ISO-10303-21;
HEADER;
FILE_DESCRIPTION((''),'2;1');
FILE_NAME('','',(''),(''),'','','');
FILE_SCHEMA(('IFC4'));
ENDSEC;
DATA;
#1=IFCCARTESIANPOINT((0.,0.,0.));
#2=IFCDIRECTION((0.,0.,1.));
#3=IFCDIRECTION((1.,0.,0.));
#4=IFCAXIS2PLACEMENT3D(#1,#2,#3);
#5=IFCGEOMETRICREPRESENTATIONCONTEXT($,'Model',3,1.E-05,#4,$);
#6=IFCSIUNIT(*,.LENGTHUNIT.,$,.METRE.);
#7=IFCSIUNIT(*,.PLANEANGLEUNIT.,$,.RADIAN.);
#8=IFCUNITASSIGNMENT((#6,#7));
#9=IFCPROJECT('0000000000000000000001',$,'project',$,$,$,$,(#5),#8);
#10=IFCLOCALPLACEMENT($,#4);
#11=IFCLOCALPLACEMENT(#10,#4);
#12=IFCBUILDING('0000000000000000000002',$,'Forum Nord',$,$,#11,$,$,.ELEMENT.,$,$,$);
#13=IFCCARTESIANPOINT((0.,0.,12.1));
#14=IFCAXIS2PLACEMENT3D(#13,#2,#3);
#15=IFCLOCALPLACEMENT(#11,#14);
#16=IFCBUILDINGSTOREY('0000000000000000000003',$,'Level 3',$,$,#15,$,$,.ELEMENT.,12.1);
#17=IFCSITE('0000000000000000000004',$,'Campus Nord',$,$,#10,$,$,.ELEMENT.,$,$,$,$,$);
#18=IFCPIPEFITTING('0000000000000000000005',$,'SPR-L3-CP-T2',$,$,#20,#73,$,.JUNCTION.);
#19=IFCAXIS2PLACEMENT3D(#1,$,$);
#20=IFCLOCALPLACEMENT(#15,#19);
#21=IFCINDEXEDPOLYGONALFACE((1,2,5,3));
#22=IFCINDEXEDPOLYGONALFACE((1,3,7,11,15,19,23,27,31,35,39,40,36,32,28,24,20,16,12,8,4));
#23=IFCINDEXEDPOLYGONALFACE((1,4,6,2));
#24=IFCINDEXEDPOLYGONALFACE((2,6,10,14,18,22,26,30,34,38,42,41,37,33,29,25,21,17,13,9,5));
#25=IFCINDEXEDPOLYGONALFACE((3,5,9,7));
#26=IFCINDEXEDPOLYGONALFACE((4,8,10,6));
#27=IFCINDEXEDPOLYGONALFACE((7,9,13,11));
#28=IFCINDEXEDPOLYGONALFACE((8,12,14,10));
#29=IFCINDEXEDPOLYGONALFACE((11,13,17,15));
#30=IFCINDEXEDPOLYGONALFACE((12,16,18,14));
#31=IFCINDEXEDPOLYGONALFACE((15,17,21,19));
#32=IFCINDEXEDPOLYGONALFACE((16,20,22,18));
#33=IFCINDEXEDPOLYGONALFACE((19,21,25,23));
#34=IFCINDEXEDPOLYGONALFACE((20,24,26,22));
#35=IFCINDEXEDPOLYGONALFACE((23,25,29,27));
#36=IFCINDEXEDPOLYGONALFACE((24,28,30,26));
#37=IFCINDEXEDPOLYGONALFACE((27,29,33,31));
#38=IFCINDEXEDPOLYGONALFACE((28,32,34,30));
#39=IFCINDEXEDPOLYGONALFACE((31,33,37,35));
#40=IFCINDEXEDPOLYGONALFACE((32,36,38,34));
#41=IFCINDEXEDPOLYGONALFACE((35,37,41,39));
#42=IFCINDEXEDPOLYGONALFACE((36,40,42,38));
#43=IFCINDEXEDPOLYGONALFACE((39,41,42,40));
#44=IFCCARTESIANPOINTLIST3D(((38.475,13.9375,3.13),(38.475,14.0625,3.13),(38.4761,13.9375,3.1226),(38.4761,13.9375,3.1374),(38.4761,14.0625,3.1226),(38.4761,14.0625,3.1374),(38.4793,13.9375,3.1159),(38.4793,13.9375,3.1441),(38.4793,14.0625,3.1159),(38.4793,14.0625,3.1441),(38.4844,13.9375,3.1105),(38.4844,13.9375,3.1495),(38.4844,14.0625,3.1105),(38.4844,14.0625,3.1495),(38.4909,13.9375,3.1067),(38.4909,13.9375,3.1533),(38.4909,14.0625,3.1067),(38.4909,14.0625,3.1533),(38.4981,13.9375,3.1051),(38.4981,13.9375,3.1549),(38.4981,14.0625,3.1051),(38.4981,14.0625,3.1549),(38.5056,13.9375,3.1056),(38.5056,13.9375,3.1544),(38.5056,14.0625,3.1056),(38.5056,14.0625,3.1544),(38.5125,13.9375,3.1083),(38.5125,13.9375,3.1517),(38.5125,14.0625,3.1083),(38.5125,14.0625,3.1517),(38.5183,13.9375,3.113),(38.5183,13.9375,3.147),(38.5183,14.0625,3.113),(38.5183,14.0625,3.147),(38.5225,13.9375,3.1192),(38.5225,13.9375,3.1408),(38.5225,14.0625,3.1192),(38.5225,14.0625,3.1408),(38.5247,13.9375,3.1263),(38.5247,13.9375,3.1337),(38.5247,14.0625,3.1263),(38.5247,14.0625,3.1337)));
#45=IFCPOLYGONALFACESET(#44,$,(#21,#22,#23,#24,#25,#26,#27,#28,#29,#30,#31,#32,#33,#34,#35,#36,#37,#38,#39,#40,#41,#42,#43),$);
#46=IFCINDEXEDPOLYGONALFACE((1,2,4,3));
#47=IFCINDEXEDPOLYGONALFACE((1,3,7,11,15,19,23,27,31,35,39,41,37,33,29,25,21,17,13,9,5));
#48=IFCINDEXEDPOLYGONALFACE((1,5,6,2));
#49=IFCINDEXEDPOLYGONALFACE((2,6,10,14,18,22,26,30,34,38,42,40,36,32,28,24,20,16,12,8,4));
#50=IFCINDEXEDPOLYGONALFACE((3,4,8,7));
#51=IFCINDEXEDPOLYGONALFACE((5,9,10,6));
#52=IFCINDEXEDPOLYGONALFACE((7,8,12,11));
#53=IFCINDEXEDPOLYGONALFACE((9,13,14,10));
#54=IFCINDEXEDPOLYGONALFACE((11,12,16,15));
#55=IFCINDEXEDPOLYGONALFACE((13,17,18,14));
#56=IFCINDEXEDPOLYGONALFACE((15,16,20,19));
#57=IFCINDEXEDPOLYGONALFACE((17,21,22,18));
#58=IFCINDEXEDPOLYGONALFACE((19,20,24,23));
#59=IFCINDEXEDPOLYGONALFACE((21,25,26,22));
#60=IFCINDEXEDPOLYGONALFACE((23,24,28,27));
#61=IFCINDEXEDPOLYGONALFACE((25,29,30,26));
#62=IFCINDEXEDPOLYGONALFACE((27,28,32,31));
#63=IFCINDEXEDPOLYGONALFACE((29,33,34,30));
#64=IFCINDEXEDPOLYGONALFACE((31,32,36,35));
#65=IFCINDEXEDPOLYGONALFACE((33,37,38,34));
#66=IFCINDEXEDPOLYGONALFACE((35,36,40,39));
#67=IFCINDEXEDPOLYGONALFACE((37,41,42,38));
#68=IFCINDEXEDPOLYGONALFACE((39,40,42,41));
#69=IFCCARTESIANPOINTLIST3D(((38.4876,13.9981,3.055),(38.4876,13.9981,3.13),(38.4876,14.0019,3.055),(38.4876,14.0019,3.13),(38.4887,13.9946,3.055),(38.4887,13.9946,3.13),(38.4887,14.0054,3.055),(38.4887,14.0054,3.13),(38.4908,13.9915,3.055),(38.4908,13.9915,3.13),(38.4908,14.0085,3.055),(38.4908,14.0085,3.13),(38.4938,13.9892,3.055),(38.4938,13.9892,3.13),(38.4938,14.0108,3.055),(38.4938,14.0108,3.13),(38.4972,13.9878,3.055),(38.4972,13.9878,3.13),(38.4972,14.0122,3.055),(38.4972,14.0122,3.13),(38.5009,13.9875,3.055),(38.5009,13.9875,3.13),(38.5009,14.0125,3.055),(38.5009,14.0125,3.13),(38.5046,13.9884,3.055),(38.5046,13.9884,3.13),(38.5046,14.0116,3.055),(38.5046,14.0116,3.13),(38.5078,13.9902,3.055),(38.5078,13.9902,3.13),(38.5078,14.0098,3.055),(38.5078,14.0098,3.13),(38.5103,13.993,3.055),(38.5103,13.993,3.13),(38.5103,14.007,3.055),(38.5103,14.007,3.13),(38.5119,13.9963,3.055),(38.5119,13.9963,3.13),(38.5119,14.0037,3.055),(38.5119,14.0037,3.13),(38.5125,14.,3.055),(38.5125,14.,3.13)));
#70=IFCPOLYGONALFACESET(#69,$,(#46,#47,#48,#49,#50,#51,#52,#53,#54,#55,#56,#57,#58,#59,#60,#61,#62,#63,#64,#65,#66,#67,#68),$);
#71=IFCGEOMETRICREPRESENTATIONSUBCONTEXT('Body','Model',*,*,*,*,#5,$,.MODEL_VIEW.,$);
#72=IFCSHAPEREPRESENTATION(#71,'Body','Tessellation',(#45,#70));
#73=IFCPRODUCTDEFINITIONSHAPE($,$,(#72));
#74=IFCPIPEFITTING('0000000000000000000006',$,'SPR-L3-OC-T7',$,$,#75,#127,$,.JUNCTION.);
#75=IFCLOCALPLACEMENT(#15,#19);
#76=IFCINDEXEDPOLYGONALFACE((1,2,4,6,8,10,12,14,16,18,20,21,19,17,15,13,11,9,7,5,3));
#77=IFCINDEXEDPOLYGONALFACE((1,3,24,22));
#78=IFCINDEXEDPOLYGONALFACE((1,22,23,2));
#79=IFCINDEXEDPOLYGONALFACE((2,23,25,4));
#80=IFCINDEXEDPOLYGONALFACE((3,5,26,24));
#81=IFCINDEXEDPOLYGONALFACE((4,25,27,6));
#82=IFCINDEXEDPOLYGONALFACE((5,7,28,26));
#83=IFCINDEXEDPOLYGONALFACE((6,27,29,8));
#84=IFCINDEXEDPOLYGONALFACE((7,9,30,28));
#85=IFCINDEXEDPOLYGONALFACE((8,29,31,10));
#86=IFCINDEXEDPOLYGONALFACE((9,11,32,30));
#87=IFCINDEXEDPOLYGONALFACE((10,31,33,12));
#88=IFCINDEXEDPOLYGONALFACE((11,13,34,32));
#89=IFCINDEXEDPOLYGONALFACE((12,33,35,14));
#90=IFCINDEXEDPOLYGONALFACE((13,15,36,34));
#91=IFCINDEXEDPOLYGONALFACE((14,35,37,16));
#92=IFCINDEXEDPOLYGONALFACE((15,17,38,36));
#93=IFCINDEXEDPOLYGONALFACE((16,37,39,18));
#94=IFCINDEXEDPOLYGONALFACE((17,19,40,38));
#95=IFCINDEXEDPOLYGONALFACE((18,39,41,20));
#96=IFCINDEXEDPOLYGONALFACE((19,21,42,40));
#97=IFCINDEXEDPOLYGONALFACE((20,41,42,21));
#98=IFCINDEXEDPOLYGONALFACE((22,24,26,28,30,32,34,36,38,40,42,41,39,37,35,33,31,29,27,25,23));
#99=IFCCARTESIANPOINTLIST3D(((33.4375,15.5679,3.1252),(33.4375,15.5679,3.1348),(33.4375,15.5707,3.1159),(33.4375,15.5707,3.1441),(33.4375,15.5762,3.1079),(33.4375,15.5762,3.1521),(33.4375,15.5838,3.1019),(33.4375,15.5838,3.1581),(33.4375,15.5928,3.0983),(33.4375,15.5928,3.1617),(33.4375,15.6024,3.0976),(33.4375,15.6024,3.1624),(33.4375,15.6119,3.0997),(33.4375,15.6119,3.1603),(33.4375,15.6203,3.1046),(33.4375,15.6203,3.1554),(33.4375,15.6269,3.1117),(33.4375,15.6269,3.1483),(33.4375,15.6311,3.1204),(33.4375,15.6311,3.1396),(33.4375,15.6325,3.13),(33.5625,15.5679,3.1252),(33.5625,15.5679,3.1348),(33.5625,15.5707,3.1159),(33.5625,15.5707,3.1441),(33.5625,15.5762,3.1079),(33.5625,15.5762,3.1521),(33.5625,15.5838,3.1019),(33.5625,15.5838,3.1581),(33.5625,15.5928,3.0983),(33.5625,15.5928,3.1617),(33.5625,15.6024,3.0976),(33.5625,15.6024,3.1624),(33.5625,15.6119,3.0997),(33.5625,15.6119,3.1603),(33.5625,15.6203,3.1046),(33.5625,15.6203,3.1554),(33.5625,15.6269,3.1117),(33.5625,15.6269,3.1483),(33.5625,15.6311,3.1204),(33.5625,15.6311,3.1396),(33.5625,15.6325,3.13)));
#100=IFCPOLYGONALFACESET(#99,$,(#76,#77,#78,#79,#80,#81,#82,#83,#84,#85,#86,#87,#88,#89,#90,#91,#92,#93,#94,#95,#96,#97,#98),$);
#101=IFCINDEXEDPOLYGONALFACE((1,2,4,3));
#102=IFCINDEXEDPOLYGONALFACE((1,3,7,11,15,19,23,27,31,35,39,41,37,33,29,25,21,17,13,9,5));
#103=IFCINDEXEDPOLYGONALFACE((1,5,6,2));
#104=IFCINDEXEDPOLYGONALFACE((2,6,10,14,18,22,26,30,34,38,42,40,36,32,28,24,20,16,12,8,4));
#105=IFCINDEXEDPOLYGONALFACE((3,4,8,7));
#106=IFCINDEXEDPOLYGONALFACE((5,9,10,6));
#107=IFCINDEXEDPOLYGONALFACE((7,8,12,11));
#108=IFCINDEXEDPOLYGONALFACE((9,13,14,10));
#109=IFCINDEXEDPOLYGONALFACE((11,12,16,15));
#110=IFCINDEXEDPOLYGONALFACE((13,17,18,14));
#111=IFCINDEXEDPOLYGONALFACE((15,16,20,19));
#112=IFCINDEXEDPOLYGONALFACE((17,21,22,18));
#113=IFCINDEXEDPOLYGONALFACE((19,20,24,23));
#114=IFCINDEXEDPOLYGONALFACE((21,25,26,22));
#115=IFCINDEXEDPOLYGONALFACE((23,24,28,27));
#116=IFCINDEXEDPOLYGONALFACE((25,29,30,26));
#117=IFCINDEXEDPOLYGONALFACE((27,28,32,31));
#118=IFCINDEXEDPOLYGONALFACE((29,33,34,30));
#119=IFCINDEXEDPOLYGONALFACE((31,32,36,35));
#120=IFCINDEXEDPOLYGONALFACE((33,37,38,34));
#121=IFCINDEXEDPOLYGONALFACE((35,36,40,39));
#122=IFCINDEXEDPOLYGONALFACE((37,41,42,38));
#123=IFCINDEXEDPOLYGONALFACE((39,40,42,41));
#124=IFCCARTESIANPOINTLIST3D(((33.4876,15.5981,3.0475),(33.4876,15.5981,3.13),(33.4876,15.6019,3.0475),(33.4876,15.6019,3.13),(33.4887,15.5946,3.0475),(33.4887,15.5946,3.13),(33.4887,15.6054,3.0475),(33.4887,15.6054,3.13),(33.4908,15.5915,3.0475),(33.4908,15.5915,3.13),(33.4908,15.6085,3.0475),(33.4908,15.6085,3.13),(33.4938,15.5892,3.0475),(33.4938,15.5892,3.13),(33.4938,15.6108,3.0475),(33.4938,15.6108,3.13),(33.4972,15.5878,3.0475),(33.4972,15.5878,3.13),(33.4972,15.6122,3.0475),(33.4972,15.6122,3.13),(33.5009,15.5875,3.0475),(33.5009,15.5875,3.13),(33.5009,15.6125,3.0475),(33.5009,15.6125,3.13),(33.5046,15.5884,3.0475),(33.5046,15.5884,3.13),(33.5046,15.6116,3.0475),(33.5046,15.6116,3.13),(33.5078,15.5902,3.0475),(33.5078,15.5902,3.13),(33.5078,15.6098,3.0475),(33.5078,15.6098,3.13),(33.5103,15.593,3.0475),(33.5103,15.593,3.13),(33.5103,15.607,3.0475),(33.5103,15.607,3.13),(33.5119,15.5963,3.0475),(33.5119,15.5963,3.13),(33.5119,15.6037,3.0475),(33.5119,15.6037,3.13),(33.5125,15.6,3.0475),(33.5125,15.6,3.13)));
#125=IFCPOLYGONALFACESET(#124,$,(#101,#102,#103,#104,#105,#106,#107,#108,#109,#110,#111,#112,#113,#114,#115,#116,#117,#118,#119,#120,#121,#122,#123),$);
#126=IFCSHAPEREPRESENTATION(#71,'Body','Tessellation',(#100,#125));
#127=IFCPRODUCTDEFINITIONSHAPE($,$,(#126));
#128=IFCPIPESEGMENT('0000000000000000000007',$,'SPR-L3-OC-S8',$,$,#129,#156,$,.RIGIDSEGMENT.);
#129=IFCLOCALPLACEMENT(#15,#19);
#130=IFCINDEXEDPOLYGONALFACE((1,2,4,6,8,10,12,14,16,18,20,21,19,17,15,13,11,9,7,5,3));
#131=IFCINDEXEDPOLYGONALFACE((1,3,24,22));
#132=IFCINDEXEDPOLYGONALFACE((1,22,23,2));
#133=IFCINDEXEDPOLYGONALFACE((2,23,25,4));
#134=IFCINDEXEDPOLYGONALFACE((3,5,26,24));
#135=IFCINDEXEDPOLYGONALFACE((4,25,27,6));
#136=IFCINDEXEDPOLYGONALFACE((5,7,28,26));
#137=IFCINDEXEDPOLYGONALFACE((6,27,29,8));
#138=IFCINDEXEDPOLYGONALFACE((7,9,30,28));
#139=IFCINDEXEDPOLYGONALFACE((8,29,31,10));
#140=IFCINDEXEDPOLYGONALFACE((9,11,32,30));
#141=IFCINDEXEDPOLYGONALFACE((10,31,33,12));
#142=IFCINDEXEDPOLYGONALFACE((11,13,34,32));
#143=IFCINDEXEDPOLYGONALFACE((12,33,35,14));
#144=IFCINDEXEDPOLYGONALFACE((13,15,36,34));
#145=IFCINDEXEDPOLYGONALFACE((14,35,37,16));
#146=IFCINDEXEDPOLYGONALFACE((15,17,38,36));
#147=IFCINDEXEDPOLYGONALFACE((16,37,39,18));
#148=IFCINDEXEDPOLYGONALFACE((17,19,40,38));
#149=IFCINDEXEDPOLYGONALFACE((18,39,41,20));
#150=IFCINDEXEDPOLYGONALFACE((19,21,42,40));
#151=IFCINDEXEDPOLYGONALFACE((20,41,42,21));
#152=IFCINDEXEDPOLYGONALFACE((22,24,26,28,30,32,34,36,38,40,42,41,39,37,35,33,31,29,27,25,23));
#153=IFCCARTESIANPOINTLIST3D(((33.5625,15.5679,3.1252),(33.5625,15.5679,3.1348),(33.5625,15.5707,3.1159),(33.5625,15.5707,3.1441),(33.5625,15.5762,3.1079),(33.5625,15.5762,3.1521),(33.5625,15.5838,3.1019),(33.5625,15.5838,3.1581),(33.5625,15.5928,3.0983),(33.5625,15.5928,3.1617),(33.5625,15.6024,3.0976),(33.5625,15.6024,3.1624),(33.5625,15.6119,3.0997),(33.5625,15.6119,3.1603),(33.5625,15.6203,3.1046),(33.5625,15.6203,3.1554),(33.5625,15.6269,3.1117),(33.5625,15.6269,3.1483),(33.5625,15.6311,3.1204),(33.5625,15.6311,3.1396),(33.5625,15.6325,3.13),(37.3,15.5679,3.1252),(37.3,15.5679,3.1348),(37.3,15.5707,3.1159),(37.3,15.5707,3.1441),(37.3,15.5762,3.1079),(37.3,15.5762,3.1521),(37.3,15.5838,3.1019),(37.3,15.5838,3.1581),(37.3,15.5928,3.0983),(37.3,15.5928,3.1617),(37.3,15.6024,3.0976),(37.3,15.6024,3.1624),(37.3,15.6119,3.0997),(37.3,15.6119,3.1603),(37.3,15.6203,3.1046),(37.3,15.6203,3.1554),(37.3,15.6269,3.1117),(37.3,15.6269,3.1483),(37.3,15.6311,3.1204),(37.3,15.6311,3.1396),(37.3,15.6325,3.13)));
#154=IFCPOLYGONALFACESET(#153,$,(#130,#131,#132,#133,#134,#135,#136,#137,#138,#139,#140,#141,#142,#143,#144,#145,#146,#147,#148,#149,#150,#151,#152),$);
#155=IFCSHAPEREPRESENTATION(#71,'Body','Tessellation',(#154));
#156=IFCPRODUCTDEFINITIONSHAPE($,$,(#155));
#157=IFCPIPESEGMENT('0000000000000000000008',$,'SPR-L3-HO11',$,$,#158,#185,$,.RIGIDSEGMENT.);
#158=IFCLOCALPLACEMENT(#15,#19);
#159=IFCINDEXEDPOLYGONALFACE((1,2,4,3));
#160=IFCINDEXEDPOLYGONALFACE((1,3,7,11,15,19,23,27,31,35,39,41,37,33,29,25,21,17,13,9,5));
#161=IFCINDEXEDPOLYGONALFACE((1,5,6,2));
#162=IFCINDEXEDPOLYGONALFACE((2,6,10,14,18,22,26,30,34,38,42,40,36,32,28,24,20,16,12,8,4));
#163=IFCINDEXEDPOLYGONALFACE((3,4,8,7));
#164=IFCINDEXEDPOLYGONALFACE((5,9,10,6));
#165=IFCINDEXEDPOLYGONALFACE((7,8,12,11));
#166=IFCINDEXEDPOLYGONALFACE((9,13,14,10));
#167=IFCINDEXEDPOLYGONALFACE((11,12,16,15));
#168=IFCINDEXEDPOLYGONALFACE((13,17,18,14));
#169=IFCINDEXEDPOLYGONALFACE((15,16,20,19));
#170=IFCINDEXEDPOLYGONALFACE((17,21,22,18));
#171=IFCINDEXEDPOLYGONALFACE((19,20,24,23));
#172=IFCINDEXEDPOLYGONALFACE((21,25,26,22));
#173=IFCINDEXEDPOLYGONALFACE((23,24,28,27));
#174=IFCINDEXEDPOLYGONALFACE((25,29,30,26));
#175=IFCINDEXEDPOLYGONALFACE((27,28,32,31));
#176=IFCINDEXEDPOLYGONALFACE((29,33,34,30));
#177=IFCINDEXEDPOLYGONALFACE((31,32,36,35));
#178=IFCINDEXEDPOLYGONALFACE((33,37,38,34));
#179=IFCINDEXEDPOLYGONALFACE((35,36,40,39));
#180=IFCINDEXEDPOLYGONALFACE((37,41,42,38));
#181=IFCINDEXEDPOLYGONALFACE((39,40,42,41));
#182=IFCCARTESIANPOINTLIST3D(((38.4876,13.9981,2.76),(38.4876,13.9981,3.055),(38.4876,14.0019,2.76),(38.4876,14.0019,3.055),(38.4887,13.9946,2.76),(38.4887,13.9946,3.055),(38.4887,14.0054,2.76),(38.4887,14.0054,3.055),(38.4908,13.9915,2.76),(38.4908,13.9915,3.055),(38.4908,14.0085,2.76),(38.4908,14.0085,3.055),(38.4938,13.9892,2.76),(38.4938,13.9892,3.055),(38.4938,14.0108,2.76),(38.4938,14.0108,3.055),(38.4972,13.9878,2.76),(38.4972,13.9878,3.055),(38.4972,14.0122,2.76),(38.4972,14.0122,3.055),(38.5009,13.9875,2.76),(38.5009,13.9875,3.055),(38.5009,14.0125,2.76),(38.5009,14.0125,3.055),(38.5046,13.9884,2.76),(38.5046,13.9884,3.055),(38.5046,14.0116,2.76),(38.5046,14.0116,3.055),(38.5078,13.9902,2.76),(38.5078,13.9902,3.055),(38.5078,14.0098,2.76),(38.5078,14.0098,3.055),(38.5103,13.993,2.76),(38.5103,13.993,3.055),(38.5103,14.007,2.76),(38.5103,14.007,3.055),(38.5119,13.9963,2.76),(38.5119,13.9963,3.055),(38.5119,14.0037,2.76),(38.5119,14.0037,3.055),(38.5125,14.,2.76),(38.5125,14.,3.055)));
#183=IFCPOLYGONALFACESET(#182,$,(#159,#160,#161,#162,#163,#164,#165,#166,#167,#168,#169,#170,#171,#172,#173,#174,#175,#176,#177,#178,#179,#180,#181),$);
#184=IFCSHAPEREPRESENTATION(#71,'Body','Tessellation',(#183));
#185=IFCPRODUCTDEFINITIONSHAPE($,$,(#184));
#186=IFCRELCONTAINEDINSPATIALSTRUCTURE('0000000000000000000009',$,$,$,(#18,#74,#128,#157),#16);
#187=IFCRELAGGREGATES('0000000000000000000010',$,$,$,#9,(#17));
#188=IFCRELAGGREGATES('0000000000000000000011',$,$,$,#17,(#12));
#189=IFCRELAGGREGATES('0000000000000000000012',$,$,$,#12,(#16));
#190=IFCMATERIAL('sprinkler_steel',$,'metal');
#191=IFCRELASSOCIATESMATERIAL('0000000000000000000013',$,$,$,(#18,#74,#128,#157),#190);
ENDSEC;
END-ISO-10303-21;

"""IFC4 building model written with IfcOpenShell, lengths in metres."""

from ifc_helpers import new_model, si_unit, frame, origin_with_axes, origin_2d_with_axis, place, context, subcontext, project, spatial, circle, extrude, material, element, save


model = new_model("IFC4")

# Units and contexts
model_context = context("Model", 3, precision=1e-05, world=origin_with_axes())
body_context = subcontext(model_context, "Body", "Model", "MODEL_VIEW")
ifc_project = project(units=[si_unit("LENGTHUNIT", "METRE"), si_unit("PLANEANGLEUNIT", "RADIAN")], contexts=[model_context])

# Site, building, storey
site_placement = place(None, origin_with_axes())
site = spatial("IfcSite", under=ifc_project, at=site_placement, Name="Campus Nord", CompositionType="ELEMENT")
building_placement = place(site_placement, origin_with_axes())
building = spatial("IfcBuilding", under=site, at=building_placement, Name="Forum Nord", CompositionType="ELEMENT")
storey_placement = place(building_placement, frame((0.0, 0.0, 12.1), z_axis=(0.0, 0.0, 1.0), x_axis=(1.0, 0.0, 0.0)))
storey = spatial("IfcBuildingStorey", under=building, at=storey_placement, Name="Level 3", CompositionType="ELEMENT", Elevation=12.1)

# Pipe fittings
ifc_material_1 = material(Name="sprinkler_steel", Category="metal")
pipe_fitting_1_placement = place(storey_placement, frame((38.5, 13.9375, 3.13), z_axis=(0.0, 1.0, 0.0), x_axis=(-1.0, 0.0, 0.0)))
element("IfcPipeFitting", 1, at=pipe_fitting_1_placement, inside=storey, material=ifc_material_1, Name="SPR-L3-CP-T2", PredefinedType="JUNCTION", context=body_context, shape_type="SweptSolid", body=[
    extrude(circle(Radius=0.025, at=origin_2d_with_axis()), origin_with_axes(), (0.0, 0.0, 1.0), 0.125),
    extrude(circle(Radius=0.0125, at=origin_2d_with_axis()), frame((0.0, 0.0, 0.0625), z_axis=(0.0, -1.0, 0.0), x_axis=(-1.0, 0.0, 0.0)), (0.0, 0.0, 1.0), 0.075),
])
pipe_fitting_2_placement = place(storey_placement, frame((33.4375, 15.6, 3.13), z_axis=(1.0, 0.0, 0.0), x_axis=(0.0, 1.0, 0.0)))
element("IfcPipeFitting", 2, at=pipe_fitting_2_placement, inside=storey, material=ifc_material_1, Name="SPR-L3-OC-T7", PredefinedType="JUNCTION", context=body_context, shape_type="SweptSolid", body=[
    extrude(circle(Radius=0.0325, at=origin_2d_with_axis()), origin_with_axes(), (0.0, 0.0, 1.0), 0.125),
    extrude(circle(Radius=0.0125, at=origin_2d_with_axis()), frame((0.0, 0.0, 0.0625), z_axis=(0.0, -1.0, 0.0), x_axis=(0.0, 0.0, 1.0)), (0.0, 0.0, 1.0), 0.0825),
])

# Pipe segments
pipe_segment_1_placement = place(storey_placement, frame((33.5625, 15.6, 3.13), z_axis=(1.0, 0.0, 0.0), x_axis=(0.0, 1.0, 0.0)))
element("IfcPipeSegment", 3, at=pipe_segment_1_placement, inside=storey, material=ifc_material_1, Name="SPR-L3-OC-S8", PredefinedType="RIGIDSEGMENT", context=body_context, shape_type="SweptSolid", body=[
    extrude(circle(Radius=0.0325, at=origin_2d_with_axis()), origin_with_axes(), (0.0, 0.0, 1.0), 3.7375),
])
pipe_segment_2_placement = place(storey_placement, frame((38.5, 14.0, 3.055), z_axis=(0.0, 0.0, -1.0), x_axis=(1.0, 0.0, 0.0)))
element("IfcPipeSegment", 4, at=pipe_segment_2_placement, inside=storey, material=ifc_material_1, Name="SPR-L3-HO11", PredefinedType="RIGIDSEGMENT", context=body_context, shape_type="SweptSolid", body=[
    extrude(circle(Radius=0.0125, at=origin_2d_with_axis()), origin_with_axes(), (0.0, 0.0, 1.0), 0.295),
])

save(model, "model.ifc")
